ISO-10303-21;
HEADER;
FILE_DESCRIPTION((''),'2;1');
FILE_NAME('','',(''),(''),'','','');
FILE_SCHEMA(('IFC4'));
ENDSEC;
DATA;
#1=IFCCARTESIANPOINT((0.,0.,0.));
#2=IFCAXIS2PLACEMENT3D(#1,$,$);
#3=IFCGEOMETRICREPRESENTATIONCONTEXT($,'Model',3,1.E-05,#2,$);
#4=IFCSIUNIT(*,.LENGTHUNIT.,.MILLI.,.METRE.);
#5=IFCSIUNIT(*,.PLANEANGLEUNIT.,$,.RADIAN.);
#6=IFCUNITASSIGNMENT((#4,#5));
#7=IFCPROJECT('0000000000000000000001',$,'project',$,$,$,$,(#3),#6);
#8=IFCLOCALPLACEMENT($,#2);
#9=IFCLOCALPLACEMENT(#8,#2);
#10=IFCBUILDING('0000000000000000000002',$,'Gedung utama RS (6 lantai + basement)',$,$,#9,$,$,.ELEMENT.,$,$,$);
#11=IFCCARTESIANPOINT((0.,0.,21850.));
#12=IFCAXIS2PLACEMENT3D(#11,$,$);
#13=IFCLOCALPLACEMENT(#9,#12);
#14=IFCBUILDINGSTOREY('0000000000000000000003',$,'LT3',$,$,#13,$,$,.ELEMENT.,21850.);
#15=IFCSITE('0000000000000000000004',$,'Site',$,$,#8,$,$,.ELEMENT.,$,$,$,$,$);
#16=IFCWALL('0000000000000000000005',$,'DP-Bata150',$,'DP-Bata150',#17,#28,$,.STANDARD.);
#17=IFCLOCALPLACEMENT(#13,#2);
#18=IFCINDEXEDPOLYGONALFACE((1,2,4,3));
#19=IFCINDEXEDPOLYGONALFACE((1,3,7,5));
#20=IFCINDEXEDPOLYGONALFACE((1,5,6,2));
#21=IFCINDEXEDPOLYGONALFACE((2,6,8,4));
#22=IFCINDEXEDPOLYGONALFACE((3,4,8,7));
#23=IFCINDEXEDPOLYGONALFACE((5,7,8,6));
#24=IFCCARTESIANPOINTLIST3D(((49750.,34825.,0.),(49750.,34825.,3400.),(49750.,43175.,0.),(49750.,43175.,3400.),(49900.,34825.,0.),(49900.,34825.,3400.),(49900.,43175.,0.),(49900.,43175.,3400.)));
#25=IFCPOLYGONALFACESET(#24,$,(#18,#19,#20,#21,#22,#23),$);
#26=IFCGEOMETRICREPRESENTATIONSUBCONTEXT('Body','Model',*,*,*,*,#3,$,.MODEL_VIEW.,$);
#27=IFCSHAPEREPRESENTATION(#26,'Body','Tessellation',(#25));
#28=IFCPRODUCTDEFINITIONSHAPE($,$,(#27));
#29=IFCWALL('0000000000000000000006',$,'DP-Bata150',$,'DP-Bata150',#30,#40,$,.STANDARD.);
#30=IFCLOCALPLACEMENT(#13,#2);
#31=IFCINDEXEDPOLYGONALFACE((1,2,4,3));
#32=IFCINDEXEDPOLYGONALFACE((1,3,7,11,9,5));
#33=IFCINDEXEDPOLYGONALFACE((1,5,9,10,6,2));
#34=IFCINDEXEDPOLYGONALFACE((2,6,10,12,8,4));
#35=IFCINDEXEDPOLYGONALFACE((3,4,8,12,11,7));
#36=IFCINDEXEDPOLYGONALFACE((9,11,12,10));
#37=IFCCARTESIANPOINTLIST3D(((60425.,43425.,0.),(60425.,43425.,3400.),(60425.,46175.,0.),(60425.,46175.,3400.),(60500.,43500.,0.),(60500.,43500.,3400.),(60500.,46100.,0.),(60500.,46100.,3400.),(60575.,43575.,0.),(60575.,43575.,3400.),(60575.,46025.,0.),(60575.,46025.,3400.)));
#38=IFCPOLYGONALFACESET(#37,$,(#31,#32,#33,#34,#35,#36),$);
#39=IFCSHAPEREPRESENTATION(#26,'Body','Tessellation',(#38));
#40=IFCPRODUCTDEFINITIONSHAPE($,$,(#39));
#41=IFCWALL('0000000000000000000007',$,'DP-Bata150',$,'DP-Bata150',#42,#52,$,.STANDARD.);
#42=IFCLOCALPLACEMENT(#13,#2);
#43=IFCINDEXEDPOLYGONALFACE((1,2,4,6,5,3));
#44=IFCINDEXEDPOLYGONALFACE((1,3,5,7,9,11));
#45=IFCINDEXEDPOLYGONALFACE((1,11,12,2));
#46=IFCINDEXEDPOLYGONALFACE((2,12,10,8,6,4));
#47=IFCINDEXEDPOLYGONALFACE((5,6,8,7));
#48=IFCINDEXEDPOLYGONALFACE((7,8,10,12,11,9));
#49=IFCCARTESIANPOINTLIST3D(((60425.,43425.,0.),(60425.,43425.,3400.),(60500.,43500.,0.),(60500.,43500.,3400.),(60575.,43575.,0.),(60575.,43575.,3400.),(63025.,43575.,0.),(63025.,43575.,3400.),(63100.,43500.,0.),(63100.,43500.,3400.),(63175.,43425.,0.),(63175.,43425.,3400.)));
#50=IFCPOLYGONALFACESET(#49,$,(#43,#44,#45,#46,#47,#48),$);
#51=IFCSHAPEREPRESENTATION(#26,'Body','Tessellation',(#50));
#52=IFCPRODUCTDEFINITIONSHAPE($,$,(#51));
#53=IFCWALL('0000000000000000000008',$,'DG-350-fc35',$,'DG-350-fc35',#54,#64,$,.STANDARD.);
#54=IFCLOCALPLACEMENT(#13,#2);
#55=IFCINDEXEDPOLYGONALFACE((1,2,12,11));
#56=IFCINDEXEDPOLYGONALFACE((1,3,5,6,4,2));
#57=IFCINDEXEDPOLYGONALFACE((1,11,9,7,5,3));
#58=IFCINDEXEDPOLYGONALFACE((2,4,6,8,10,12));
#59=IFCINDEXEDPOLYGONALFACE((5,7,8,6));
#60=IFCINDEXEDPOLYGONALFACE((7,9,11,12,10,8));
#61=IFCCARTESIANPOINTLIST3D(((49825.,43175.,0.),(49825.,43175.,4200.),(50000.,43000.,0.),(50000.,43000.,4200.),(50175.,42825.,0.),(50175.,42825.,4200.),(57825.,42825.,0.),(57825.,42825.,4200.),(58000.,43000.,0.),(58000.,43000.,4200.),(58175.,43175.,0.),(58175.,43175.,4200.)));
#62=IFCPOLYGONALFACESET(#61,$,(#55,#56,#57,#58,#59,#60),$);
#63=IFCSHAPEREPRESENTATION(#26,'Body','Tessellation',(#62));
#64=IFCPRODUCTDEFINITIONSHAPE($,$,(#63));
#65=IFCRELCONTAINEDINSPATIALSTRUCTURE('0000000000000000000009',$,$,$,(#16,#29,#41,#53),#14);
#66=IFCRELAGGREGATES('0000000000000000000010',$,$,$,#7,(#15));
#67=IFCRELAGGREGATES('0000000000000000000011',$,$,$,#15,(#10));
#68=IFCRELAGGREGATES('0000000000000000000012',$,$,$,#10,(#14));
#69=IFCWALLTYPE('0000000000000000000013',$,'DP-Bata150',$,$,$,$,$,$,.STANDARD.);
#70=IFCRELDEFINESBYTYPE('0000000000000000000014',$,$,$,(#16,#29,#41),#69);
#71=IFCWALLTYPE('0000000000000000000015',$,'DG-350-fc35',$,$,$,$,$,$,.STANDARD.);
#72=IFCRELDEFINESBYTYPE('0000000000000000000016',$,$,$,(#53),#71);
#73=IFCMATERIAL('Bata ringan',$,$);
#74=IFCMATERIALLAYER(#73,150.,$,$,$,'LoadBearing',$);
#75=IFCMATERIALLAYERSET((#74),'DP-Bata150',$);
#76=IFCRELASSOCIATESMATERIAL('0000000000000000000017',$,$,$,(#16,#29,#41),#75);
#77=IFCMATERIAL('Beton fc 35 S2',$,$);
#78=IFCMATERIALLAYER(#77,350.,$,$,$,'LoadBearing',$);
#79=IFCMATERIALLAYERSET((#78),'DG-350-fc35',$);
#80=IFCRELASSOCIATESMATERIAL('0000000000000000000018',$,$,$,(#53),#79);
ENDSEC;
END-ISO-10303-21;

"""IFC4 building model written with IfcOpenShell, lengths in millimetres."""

from ifc_helpers import new_model, si_unit, frame, origin, place, context, subcontext, project, spatial, polyline, outline, extrude, material, layer, layer_set, layer_usage, type_object, element, save


model = new_model("IFC4")

# Units and contexts
model_context = context("Model", 3, precision=1e-05, world=origin())
body_context = subcontext(model_context, "Body", "Model", "MODEL_VIEW")
ifc_project = project(units=[si_unit("LENGTHUNIT", "METRE", prefix="MILLI"), si_unit("PLANEANGLEUNIT", "RADIAN")], contexts=[model_context])

# Site, building, storey
site_placement = place(None, origin())
site = spatial("IfcSite", under=ifc_project, at=site_placement, Name="Site", CompositionType="ELEMENT")
building_placement = place(site_placement, origin())
building = spatial("IfcBuilding", under=site, at=building_placement, Name="Gedung utama RS (6 lantai + basement)", CompositionType="ELEMENT")
storey_placement = place(building_placement, frame((0.0, 0.0, 21850.0)))
storey = spatial("IfcBuildingStorey", under=building, at=storey_placement, Name="LT3", CompositionType="ELEMENT", Elevation=21850.0)

# Shared definitions
ifc_material_1 = material(Name="Bata ringan")

# Shared definitions
ifc_layer_1 = layer(ifc_material_1, 150.0, Category="LoadBearing")
ifc_layer_set_1 = layer_set([ifc_layer_1], Name="DP-Bata150")
ifc_layer_usage_1 = layer_usage(ifc_layer_set_1, "AXIS2", "NEGATIVE", 75.0)
wall_type_1 = type_object("IfcWallType", Name="DP-Bata150", PredefinedType="STANDARD")

# Walls
for number, where, z_axis, x_axis, name in (
    (1, (49825.0, 43175.0, 0.0), (0.0, 0.0, 1.0), (0.0, -1.0, 0.0), "DP-Bata150"),
):
    element("IfcWall", number, at=place(storey_placement, frame(where, z_axis=z_axis, x_axis=x_axis)), inside=storey, type_object=wall_type_1, material=ifc_layer_usage_1, Name=name, ObjectType="DP-Bata150", PredefinedType="STANDARD", context=body_context, shape_type="SweptSolid", body=[
        extrude(outline(polyline([(0.0, -75.0), (0.0, 75.0), (8350.0, 75.0), (8350.0, -75.0), (0.0, -75.0)])), origin(), (0.0, 0.0, 1.0), 3400.0),
    ])
for number, where, z_axis, x_axis, name in (
    (2, (60500.0, 46100.0, 0.0), (0.0, 0.0, 1.0), (0.0, -1.0, 0.0), "DP-Bata150"),
    (3, (60500.0, 43500.0, 0.0), (0.0, 0.0, 1.0), (1.0, 0.0, 0.0), "DP-Bata150"),
):
    element("IfcWall", number, at=place(storey_placement, frame(where, z_axis=z_axis, x_axis=x_axis)), inside=storey, type_object=wall_type_1, material=ifc_layer_usage_1, Name=name, ObjectType="DP-Bata150", PredefinedType="STANDARD", context=body_context, shape_type="SweptSolid", body=[
        extrude(outline(polyline([(-75.0, -75.0), (0.0, 0.0), (75.0, 75.0), (2525.0, 75.0), (2600.0, 0.0), (2675.0, -75.0), (-75.0, -75.0)])), origin(), (0.0, 0.0, 1.0), 3400.0),
    ])
ifc_material_2 = material(Name="Beton fc 35 S2")
ifc_layer_2 = layer(ifc_material_2, 350.0, Category="LoadBearing")
ifc_layer_set_2 = layer_set([ifc_layer_2], Name="DG-350-fc35")
ifc_layer_usage_2 = layer_usage(ifc_layer_set_2, "AXIS2", "NEGATIVE", 175.0)
wall_type_2 = type_object("IfcWallType", Name="DG-350-fc35", PredefinedType="STANDARD")
wall_1_placement = place(storey_placement, frame((58000.0, 43000.0, 0.0), z_axis=(0.0, 0.0, 1.0), x_axis=(-1.0, 0.0, 0.0)))
element("IfcWall", 4, at=wall_1_placement, inside=storey, type_object=wall_type_2, material=ifc_layer_usage_2, Name="DG-350-fc35", ObjectType="DG-350-fc35", PredefinedType="STANDARD", context=body_context, shape_type="SweptSolid", body=[
    extrude(outline(polyline([(-175.0, -175.0), (0.0, 0.0), (175.0, 175.0), (7825.0, 175.0), (8000.0, 0.0), (8175.0, -175.0), (-175.0, -175.0)])), origin(), (0.0, 0.0, 1.0), 4200.0),
])

save(model, "model.ifc")
